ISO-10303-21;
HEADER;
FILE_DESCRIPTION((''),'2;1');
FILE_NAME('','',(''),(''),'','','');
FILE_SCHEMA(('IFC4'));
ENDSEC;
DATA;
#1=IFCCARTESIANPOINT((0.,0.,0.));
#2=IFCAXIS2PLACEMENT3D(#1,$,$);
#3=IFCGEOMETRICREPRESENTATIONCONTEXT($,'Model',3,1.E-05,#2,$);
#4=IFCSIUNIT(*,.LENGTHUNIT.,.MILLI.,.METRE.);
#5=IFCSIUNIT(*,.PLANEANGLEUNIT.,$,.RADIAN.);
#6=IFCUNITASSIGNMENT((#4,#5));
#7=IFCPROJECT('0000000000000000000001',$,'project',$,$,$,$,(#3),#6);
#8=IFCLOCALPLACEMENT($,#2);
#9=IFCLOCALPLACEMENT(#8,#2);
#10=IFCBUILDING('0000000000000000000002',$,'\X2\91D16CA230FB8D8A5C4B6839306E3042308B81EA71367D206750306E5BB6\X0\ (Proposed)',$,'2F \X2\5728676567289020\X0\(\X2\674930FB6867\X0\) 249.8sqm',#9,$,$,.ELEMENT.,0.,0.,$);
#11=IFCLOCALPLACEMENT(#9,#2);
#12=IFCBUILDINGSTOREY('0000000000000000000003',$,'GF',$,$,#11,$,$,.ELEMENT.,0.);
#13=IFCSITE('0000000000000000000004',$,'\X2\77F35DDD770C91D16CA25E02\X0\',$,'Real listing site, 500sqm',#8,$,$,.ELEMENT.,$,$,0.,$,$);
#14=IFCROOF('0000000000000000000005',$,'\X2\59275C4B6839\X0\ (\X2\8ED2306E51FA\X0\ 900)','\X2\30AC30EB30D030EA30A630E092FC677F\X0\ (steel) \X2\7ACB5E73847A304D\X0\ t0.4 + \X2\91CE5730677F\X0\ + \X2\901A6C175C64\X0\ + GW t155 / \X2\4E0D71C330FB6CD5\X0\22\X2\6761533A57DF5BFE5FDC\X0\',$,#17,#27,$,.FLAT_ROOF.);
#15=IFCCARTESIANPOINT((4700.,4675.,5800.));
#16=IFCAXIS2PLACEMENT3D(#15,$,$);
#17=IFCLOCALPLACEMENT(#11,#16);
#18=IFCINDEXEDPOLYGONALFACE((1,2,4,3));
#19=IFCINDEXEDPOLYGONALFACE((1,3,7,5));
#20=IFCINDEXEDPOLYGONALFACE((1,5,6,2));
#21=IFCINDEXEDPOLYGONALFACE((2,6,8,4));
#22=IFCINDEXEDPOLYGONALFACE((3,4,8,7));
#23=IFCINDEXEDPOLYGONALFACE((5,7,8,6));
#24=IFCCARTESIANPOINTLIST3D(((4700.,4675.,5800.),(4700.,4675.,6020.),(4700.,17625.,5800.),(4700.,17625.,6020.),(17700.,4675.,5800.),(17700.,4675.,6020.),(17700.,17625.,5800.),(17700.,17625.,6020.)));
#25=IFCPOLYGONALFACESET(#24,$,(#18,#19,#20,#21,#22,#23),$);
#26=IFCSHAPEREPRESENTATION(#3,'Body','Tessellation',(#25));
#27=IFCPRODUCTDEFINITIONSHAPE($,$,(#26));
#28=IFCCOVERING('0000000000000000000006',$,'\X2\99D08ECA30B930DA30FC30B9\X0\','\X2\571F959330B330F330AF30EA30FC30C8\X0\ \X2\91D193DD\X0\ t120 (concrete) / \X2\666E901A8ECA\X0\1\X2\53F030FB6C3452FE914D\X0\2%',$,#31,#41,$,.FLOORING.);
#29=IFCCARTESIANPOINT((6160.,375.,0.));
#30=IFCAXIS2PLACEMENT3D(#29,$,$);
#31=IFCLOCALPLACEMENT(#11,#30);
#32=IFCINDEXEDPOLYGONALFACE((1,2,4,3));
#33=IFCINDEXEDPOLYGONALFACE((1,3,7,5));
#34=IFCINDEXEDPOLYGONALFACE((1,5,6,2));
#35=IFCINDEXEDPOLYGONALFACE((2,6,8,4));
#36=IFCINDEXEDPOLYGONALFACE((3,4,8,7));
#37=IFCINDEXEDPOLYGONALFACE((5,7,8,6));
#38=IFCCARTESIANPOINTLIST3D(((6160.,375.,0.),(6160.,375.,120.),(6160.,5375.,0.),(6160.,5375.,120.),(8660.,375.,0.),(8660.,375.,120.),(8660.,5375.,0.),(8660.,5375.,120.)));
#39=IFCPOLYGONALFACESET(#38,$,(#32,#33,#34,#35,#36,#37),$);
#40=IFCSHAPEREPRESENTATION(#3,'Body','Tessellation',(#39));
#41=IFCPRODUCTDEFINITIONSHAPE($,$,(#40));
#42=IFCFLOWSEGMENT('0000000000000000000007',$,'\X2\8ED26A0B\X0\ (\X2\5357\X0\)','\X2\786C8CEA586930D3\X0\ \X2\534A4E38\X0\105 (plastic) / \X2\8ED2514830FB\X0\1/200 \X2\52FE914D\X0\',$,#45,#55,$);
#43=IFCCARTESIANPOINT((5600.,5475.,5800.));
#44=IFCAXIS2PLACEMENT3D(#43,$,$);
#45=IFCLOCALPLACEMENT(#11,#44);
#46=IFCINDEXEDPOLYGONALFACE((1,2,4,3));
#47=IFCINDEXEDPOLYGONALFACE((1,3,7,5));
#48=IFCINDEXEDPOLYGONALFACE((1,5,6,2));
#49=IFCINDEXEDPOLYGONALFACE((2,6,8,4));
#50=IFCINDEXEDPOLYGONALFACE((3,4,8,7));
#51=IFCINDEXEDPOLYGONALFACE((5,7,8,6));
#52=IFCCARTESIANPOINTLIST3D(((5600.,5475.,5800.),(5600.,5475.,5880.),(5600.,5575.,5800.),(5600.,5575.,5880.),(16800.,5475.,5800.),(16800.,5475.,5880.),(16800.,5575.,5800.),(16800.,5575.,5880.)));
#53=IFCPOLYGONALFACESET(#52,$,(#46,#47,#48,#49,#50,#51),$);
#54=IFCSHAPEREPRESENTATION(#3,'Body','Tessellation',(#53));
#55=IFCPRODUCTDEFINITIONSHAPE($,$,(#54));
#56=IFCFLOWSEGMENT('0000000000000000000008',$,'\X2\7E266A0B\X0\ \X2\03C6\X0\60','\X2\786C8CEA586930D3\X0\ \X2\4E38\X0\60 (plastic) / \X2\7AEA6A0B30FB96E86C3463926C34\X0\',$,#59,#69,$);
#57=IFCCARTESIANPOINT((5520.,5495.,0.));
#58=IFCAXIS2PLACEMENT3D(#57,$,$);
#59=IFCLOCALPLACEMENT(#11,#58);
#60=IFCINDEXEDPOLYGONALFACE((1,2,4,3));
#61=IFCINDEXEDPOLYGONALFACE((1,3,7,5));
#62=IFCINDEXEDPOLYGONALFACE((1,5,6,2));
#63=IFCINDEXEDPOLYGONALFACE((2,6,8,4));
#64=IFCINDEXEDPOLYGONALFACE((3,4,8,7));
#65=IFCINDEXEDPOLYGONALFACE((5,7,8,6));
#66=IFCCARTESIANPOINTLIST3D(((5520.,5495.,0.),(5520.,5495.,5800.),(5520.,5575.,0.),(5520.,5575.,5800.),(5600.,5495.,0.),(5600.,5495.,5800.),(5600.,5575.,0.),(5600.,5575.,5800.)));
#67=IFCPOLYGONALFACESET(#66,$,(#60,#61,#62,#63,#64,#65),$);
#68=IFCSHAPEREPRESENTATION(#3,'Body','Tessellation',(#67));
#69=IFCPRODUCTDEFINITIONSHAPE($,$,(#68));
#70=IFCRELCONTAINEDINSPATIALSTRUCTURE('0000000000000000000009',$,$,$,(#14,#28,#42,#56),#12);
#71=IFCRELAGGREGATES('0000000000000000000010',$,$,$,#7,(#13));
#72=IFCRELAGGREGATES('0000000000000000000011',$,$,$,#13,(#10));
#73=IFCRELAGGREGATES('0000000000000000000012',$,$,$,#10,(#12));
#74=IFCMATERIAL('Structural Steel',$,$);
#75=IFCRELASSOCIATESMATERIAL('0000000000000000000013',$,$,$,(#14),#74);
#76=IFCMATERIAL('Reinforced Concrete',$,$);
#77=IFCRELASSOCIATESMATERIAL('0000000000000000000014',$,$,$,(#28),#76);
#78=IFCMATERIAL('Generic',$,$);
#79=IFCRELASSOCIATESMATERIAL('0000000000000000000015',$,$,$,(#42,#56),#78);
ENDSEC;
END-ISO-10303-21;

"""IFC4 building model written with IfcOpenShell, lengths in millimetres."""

from ifc_helpers import new_model, si_unit, frame, frame_2d, origin, place, context, project, spatial, rectangle, extrude, material, element, save


model = new_model("IFC4")

# Units and contexts
model_context = context("Model", 3, precision=1e-05, world=origin())
ifc_project = project(units=[si_unit("LENGTHUNIT", "METRE", prefix="MILLI"), si_unit("PLANEANGLEUNIT", "RADIAN")], contexts=[model_context])

# Site, building, storey
site_placement = place(None, origin())
site = spatial("IfcSite", under=ifc_project, at=site_placement, Name="石川県金沢市", ObjectType="Real listing site, 500sqm", CompositionType="ELEMENT", RefElevation=0.0)
building_placement = place(site_placement, origin())
building = spatial("IfcBuilding", under=site, at=building_placement, Name="金沢・越屋根のある自然素材の家 (Proposed)", ObjectType="2F 在来木造(杉・桧) 249.8sqm", CompositionType="ELEMENT", ElevationOfRefHeight=0.0, ElevationOfTerrain=0.0)
storey_placement = place(building_placement, origin())
storey = spatial("IfcBuildingStorey", under=building, at=storey_placement, Name="GF", CompositionType="ELEMENT", Elevation=0.0)

# Shared definitions
ifc_material_1 = material(Name="Reinforced Concrete")

# Roof
ifc_material_2 = material(Name="Structural Steel")
roof_placement = place(storey_placement, frame((4700.0, 4675.0, 5800.0)))
element("IfcRoof", 1, at=roof_placement, inside=storey, material=ifc_material_2, Name="大屋根 (軒の出 900)", Description="ガルバリウム鋼板 (steel) 立平葺き t0.4 + 野地板 + 通気層 + GW t155 / 不燃・法22条区域対応", PredefinedType="FLAT_ROOF", context=model_context, shape_type="SweptSolid", body=[
    extrude(rectangle(XDim=13000.0, YDim=12950.0, at=frame_2d((6500.0, 6475.0))), frame((4700.0, 4675.0, 5800.0)), (0.0, 0.0, 1.0), 220.0),
])

# Covering
covering_placement = place(storey_placement, frame((6160.0, 375.0, 0.0)))
element("IfcCovering", 2, at=covering_placement, inside=storey, material=ifc_material_1, Name="駐車スペース", Description="土間コンクリート 金鏝 t120 (concrete) / 普通車1台・水勾配2%", PredefinedType="FLOORING", context=model_context, shape_type="SweptSolid", body=[
    extrude(rectangle(XDim=2500.0, YDim=5000.0, at=frame_2d((1250.0, 2500.0))), frame((6160.0, 375.0, 0.0)), (0.0, 0.0, 1.0), 120.0),
])

# Flow segments
ifc_material_3 = material(Name="Generic")
flow_segment_1_placement = place(storey_placement, frame((5600.0, 5475.0, 5800.0)))
element("IfcFlowSegment", 3, at=flow_segment_1_placement, inside=storey, material=ifc_material_3, Name="軒樋 (南)", Description="硬質塩ビ 半丸105 (plastic) / 軒先・1/200 勾配", context=model_context, shape_type="SweptSolid", body=[
    extrude(rectangle(XDim=11200.0, YDim=100.0, at=frame_2d((5600.0, 50.0))), frame((5600.0, 5475.0, 5800.0)), (0.0, 0.0, 1.0), 80.0),
])
flow_segment_2_placement = place(storey_placement, frame((5520.0, 5495.0, 0.0)))
element("IfcFlowSegment", 4, at=flow_segment_2_placement, inside=storey, material=ifc_material_3, Name="縦樋 φ60", Description="硬質塩ビ 丸60 (plastic) / 竪樋・雨水排水", context=model_context, shape_type="SweptSolid", body=[
    extrude(rectangle(XDim=80.0, YDim=80.0, at=frame_2d((40.0, 40.0))), frame((5520.0, 5495.0, 0.0)), (0.0, 0.0, 1.0), 5800.0),
])

save(model, "model.ifc")
